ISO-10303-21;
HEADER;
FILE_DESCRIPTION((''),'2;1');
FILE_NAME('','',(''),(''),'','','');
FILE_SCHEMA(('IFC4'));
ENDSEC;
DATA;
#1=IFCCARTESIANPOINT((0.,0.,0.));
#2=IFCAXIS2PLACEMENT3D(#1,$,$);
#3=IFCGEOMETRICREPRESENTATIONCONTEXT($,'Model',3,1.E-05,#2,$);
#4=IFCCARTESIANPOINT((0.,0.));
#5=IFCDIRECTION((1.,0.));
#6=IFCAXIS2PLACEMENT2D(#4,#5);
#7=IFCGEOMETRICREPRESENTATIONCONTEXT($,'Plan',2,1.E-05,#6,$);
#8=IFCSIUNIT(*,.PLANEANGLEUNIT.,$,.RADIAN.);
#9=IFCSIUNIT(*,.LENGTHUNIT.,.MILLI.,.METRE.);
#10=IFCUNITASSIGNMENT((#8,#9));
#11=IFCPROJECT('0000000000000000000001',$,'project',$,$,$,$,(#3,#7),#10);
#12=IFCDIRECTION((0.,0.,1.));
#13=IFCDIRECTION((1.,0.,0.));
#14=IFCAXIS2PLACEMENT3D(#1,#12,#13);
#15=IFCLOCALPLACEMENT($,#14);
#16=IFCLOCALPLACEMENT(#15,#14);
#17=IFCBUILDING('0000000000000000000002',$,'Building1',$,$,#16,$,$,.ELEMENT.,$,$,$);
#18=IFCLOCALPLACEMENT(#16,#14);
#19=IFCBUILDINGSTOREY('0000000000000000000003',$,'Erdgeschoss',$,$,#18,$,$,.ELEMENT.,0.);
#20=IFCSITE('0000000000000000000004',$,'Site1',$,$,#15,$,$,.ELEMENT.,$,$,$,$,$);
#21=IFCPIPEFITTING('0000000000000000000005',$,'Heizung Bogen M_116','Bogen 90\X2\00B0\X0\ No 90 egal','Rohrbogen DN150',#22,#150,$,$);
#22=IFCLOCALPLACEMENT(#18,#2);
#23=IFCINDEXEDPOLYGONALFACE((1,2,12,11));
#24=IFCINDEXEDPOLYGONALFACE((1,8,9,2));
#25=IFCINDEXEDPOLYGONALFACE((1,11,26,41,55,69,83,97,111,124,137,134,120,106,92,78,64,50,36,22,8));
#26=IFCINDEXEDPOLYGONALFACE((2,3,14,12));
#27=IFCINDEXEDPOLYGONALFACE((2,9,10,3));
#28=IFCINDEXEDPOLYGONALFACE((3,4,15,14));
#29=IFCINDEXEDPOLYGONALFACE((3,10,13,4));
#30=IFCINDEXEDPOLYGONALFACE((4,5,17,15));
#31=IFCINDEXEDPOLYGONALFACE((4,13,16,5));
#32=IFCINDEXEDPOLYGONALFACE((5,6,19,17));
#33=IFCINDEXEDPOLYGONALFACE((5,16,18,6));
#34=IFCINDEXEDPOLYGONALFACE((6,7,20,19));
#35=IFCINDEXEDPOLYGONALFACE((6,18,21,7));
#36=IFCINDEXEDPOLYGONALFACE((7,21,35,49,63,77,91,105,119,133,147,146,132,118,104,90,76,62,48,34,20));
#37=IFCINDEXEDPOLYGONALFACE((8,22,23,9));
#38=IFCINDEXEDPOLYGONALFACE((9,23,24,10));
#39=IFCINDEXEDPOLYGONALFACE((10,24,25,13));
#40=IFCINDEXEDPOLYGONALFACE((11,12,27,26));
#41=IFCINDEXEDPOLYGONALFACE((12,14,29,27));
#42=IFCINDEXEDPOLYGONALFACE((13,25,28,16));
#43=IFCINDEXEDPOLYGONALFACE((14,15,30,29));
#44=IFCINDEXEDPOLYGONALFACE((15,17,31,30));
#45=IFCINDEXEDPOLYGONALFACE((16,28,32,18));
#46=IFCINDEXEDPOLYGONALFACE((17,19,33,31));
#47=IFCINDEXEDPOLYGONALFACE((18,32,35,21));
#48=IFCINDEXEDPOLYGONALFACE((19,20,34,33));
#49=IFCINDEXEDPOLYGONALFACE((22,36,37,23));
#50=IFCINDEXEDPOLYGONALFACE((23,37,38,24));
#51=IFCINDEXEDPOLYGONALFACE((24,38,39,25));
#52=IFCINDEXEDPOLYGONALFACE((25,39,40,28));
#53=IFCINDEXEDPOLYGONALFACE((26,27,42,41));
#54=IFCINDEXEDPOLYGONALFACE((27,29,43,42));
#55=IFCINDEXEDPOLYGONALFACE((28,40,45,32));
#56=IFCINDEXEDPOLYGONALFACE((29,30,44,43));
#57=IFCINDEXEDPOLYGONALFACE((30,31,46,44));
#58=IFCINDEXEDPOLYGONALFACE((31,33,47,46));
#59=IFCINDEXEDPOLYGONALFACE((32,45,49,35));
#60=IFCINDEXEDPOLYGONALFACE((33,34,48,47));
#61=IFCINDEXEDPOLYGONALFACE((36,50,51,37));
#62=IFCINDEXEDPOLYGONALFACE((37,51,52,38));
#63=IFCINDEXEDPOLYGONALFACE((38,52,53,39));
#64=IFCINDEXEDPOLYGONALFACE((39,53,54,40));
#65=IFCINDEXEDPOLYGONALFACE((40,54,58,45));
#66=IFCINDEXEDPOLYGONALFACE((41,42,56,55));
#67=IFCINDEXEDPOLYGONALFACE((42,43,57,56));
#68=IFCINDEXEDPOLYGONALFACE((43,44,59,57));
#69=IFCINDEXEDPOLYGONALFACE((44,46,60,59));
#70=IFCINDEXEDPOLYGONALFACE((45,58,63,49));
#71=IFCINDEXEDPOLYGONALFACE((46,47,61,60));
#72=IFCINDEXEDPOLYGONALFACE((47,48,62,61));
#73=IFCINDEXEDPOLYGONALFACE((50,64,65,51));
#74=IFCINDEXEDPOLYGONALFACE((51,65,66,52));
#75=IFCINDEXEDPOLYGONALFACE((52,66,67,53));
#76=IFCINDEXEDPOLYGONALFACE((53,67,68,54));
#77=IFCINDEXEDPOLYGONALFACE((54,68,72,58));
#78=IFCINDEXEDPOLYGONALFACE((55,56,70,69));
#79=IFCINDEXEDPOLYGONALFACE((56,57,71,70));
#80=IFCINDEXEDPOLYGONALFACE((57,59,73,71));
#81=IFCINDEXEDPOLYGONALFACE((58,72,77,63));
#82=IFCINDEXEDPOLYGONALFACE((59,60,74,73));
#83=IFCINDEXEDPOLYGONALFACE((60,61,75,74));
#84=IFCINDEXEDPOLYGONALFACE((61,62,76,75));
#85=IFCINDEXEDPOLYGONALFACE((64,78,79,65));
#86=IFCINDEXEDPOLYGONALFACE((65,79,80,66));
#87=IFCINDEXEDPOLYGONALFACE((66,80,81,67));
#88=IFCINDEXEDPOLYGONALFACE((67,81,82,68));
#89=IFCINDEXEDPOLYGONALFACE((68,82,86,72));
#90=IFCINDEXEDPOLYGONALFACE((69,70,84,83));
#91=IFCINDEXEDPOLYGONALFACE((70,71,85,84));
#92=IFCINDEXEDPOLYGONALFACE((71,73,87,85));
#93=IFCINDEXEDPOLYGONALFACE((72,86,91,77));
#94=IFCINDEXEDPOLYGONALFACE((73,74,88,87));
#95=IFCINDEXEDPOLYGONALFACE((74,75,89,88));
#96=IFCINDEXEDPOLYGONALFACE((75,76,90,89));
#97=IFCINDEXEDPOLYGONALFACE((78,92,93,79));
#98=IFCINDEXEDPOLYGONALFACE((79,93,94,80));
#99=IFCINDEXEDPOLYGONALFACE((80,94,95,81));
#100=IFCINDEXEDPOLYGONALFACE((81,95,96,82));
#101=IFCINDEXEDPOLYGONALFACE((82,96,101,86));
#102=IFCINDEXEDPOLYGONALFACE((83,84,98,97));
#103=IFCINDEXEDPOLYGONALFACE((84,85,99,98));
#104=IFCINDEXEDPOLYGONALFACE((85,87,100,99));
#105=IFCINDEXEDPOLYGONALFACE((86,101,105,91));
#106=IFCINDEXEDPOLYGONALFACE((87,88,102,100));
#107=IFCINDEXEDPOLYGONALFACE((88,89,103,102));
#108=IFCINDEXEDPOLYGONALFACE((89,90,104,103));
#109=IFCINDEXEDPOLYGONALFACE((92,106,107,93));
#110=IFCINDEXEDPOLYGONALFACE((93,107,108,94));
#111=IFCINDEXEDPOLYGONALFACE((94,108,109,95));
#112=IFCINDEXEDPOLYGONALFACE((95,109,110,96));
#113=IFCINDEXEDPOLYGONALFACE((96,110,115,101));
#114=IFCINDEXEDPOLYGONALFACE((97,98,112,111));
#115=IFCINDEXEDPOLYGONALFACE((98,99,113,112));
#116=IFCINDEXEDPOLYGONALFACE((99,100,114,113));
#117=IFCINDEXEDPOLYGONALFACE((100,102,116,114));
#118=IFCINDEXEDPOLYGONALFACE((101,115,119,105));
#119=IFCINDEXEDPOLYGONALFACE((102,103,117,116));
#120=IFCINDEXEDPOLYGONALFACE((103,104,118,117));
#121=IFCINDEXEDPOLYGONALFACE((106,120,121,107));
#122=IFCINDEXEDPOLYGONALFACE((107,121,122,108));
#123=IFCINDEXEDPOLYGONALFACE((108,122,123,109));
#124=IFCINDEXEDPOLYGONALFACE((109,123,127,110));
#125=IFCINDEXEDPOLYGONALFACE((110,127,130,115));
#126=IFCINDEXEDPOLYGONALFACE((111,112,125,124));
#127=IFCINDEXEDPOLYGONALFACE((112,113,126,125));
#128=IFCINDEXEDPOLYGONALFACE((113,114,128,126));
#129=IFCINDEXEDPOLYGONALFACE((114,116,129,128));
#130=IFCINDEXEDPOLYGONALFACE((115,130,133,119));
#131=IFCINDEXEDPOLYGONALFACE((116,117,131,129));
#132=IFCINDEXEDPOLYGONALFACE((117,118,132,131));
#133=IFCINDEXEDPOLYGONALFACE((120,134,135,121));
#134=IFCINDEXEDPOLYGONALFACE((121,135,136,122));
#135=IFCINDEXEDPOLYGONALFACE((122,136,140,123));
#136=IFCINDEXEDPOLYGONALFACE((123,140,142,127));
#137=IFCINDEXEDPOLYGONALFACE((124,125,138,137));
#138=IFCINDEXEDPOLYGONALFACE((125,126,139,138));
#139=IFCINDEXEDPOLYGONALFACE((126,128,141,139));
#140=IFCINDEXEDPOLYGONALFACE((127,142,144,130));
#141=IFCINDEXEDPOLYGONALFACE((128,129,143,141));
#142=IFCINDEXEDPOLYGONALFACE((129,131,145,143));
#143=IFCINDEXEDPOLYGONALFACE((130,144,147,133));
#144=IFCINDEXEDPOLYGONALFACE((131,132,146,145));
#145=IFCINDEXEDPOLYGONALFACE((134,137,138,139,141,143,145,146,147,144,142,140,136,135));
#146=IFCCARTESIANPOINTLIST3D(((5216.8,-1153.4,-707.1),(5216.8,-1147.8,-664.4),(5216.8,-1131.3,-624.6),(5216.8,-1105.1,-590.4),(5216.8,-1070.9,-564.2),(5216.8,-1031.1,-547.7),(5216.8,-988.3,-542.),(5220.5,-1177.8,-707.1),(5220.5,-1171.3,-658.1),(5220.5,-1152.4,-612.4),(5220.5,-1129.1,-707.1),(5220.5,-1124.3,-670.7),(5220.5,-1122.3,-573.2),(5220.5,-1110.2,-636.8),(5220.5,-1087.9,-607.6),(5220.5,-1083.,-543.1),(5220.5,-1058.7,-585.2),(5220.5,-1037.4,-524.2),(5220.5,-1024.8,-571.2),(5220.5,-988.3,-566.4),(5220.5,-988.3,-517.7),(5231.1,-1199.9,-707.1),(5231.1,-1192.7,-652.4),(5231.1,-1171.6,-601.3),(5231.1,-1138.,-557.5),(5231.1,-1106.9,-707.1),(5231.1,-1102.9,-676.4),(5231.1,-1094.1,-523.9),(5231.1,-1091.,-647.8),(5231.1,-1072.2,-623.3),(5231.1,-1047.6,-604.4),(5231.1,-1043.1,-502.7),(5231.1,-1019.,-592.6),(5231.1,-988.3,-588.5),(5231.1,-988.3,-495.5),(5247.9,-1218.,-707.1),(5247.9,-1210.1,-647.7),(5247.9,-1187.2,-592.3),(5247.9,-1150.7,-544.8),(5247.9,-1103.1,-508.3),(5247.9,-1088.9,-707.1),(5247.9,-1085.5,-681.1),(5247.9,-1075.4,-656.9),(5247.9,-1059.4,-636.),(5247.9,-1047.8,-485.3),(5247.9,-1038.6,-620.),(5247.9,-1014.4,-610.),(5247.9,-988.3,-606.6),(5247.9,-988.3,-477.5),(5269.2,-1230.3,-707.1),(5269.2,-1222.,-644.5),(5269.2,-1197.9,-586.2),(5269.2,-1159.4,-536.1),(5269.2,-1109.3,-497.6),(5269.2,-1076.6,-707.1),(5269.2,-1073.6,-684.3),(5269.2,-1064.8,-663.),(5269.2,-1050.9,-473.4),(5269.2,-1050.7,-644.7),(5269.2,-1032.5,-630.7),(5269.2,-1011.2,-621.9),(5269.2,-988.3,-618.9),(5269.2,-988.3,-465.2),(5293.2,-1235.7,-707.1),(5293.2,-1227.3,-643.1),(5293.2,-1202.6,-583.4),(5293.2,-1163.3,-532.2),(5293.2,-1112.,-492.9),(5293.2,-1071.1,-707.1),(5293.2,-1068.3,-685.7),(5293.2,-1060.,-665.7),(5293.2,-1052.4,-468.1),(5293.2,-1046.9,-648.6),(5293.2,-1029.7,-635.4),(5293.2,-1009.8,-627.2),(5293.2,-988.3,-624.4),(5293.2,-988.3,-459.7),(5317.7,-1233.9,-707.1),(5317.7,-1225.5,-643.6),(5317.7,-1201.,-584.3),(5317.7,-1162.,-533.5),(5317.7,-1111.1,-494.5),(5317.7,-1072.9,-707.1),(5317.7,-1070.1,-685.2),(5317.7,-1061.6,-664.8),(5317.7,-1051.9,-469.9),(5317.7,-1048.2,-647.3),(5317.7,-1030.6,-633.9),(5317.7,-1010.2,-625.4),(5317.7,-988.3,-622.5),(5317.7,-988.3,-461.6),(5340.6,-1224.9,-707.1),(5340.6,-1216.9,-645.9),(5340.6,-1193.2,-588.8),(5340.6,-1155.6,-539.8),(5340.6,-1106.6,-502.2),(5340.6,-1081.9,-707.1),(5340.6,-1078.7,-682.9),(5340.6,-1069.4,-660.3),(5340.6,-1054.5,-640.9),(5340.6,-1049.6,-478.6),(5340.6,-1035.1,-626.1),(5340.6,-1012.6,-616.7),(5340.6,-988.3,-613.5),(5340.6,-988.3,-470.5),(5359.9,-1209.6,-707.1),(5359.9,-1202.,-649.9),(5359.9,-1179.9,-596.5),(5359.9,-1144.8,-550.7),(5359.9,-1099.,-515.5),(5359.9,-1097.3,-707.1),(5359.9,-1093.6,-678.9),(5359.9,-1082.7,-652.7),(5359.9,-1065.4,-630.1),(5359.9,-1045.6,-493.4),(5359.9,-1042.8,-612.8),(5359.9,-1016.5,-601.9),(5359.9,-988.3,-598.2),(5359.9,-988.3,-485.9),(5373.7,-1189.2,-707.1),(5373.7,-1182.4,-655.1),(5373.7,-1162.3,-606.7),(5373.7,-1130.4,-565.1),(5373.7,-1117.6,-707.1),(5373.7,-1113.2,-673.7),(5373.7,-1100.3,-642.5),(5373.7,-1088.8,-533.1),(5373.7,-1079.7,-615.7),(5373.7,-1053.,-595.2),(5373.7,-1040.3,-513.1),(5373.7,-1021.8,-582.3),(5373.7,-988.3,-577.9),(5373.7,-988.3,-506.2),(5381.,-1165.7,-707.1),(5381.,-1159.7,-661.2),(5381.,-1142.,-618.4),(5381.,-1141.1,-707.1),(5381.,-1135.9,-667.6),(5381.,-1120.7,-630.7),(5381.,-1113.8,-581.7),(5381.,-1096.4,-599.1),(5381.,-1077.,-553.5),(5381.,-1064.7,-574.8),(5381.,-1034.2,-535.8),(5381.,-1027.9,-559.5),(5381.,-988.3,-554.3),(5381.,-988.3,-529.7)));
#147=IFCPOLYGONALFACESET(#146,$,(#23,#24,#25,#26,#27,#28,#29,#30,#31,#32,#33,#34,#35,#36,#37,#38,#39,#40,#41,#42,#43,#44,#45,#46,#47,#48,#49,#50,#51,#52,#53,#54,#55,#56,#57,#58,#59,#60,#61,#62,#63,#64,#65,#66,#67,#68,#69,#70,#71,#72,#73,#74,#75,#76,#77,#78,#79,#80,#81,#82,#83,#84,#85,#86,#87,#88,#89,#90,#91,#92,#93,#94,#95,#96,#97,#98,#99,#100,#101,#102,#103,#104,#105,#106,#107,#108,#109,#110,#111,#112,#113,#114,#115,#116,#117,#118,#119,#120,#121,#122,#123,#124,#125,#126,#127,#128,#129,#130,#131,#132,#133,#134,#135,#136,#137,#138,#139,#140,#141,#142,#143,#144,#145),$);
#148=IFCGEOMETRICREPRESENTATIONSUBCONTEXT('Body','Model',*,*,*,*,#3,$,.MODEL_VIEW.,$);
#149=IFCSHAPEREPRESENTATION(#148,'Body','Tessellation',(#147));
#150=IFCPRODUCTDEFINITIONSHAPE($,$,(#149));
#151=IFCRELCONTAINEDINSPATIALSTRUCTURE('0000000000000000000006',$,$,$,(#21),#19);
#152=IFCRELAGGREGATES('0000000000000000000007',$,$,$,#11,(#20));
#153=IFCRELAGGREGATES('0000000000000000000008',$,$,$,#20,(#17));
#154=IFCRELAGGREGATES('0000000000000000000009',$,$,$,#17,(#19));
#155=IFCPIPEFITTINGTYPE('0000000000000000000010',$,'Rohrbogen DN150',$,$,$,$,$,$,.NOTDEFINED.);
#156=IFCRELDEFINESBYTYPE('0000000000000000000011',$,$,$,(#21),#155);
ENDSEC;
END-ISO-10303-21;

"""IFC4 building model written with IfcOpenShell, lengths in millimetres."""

from ifc_helpers import new_model, entity, si_unit, frame, origin, origin_with_axes, origin_2d_with_axis, place, context, subcontext, project, spatial, source, transform, mapped, type_object, element, save


model = new_model("IFC4")

# Units and contexts
model_context = context("Model", 3, precision=1e-05, world=origin())
plan_context = context("Plan", 2, precision=1e-05, world=origin_2d_with_axis())
body_context = subcontext(model_context, "Body", "Model", "MODEL_VIEW")
ifc_project = project(units=[si_unit("PLANEANGLEUNIT", "RADIAN"), si_unit("LENGTHUNIT", "METRE", prefix="MILLI")], contexts=[model_context, plan_context])

# Site, building, storey
site_placement = place(None, origin_with_axes())
site = spatial("IfcSite", under=ifc_project, at=site_placement, Name="Site1", CompositionType="ELEMENT")
building_placement = place(site_placement, origin_with_axes())
building = spatial("IfcBuilding", under=site, at=building_placement, Name="Building1", CompositionType="ELEMENT")
storey_placement = place(building_placement, origin_with_axes())
storey = spatial("IfcBuildingStorey", under=building, at=storey_placement, Name="Erdgeschoss", CompositionType="ELEMENT", Elevation=0.0)

# Pipe fitting
pipe_fitting_type_1 = type_object("IfcPipeFittingType", Name="Rohrbogen DN150", PredefinedType="NOTDEFINED")
shared_shape_1 = source(origin_with_axes(), body_context, "Body", "SolidModel", [
    entity("IfcRevolvedAreaSolid", entity("IfcCircleProfileDef", "AREA", None, entity("IfcAxis2Placement2D", entity("IfcCartesianPoint", [0.0, 0.0]), entity("IfcDirection", [1.0, 0.0])), 82.5), entity("IfcAxis2Placement3D", entity("IfcCartesianPoint", [-123.8, 0.0, 41.3]), entity("IfcDirection", [1.0, 0.0, 0.0]), entity("IfcDirection", [0.0, -1.0, 0.0])), entity("IfcAxis1Placement", entity("IfcCartesianPoint", [0.0, 165.1, 0.0]), entity("IfcDirection", [-1.0, 0.0, 0.0])), 1.570796),
])
pipe_fitting_1_placement = place(storey_placement, frame((5299.4, -1112.2, -583.3), z_axis=(0.0, 0.0, 1.0), x_axis=(1.0, 0.0, 0.0)))
element("IfcPipeFitting", 1, at=pipe_fitting_1_placement, inside=storey, type_object=pipe_fitting_type_1, Name="Heizung Bogen M_116", Description="Bogen 90° No 90 egal", ObjectType="Rohrbogen DN150", context=body_context, shape_type="MappedRepresentation", body=[
    mapped(shared_shape_1, transform((0.0, 0.0, 0.0), x_axis=(0.0, -1.0, 0.0), y_axis=(1.0, 0.0, 0.0), z_axis=(0.0, 0.0, 1.0), scale=1.0)),
])

save(model, "model.ifc")
